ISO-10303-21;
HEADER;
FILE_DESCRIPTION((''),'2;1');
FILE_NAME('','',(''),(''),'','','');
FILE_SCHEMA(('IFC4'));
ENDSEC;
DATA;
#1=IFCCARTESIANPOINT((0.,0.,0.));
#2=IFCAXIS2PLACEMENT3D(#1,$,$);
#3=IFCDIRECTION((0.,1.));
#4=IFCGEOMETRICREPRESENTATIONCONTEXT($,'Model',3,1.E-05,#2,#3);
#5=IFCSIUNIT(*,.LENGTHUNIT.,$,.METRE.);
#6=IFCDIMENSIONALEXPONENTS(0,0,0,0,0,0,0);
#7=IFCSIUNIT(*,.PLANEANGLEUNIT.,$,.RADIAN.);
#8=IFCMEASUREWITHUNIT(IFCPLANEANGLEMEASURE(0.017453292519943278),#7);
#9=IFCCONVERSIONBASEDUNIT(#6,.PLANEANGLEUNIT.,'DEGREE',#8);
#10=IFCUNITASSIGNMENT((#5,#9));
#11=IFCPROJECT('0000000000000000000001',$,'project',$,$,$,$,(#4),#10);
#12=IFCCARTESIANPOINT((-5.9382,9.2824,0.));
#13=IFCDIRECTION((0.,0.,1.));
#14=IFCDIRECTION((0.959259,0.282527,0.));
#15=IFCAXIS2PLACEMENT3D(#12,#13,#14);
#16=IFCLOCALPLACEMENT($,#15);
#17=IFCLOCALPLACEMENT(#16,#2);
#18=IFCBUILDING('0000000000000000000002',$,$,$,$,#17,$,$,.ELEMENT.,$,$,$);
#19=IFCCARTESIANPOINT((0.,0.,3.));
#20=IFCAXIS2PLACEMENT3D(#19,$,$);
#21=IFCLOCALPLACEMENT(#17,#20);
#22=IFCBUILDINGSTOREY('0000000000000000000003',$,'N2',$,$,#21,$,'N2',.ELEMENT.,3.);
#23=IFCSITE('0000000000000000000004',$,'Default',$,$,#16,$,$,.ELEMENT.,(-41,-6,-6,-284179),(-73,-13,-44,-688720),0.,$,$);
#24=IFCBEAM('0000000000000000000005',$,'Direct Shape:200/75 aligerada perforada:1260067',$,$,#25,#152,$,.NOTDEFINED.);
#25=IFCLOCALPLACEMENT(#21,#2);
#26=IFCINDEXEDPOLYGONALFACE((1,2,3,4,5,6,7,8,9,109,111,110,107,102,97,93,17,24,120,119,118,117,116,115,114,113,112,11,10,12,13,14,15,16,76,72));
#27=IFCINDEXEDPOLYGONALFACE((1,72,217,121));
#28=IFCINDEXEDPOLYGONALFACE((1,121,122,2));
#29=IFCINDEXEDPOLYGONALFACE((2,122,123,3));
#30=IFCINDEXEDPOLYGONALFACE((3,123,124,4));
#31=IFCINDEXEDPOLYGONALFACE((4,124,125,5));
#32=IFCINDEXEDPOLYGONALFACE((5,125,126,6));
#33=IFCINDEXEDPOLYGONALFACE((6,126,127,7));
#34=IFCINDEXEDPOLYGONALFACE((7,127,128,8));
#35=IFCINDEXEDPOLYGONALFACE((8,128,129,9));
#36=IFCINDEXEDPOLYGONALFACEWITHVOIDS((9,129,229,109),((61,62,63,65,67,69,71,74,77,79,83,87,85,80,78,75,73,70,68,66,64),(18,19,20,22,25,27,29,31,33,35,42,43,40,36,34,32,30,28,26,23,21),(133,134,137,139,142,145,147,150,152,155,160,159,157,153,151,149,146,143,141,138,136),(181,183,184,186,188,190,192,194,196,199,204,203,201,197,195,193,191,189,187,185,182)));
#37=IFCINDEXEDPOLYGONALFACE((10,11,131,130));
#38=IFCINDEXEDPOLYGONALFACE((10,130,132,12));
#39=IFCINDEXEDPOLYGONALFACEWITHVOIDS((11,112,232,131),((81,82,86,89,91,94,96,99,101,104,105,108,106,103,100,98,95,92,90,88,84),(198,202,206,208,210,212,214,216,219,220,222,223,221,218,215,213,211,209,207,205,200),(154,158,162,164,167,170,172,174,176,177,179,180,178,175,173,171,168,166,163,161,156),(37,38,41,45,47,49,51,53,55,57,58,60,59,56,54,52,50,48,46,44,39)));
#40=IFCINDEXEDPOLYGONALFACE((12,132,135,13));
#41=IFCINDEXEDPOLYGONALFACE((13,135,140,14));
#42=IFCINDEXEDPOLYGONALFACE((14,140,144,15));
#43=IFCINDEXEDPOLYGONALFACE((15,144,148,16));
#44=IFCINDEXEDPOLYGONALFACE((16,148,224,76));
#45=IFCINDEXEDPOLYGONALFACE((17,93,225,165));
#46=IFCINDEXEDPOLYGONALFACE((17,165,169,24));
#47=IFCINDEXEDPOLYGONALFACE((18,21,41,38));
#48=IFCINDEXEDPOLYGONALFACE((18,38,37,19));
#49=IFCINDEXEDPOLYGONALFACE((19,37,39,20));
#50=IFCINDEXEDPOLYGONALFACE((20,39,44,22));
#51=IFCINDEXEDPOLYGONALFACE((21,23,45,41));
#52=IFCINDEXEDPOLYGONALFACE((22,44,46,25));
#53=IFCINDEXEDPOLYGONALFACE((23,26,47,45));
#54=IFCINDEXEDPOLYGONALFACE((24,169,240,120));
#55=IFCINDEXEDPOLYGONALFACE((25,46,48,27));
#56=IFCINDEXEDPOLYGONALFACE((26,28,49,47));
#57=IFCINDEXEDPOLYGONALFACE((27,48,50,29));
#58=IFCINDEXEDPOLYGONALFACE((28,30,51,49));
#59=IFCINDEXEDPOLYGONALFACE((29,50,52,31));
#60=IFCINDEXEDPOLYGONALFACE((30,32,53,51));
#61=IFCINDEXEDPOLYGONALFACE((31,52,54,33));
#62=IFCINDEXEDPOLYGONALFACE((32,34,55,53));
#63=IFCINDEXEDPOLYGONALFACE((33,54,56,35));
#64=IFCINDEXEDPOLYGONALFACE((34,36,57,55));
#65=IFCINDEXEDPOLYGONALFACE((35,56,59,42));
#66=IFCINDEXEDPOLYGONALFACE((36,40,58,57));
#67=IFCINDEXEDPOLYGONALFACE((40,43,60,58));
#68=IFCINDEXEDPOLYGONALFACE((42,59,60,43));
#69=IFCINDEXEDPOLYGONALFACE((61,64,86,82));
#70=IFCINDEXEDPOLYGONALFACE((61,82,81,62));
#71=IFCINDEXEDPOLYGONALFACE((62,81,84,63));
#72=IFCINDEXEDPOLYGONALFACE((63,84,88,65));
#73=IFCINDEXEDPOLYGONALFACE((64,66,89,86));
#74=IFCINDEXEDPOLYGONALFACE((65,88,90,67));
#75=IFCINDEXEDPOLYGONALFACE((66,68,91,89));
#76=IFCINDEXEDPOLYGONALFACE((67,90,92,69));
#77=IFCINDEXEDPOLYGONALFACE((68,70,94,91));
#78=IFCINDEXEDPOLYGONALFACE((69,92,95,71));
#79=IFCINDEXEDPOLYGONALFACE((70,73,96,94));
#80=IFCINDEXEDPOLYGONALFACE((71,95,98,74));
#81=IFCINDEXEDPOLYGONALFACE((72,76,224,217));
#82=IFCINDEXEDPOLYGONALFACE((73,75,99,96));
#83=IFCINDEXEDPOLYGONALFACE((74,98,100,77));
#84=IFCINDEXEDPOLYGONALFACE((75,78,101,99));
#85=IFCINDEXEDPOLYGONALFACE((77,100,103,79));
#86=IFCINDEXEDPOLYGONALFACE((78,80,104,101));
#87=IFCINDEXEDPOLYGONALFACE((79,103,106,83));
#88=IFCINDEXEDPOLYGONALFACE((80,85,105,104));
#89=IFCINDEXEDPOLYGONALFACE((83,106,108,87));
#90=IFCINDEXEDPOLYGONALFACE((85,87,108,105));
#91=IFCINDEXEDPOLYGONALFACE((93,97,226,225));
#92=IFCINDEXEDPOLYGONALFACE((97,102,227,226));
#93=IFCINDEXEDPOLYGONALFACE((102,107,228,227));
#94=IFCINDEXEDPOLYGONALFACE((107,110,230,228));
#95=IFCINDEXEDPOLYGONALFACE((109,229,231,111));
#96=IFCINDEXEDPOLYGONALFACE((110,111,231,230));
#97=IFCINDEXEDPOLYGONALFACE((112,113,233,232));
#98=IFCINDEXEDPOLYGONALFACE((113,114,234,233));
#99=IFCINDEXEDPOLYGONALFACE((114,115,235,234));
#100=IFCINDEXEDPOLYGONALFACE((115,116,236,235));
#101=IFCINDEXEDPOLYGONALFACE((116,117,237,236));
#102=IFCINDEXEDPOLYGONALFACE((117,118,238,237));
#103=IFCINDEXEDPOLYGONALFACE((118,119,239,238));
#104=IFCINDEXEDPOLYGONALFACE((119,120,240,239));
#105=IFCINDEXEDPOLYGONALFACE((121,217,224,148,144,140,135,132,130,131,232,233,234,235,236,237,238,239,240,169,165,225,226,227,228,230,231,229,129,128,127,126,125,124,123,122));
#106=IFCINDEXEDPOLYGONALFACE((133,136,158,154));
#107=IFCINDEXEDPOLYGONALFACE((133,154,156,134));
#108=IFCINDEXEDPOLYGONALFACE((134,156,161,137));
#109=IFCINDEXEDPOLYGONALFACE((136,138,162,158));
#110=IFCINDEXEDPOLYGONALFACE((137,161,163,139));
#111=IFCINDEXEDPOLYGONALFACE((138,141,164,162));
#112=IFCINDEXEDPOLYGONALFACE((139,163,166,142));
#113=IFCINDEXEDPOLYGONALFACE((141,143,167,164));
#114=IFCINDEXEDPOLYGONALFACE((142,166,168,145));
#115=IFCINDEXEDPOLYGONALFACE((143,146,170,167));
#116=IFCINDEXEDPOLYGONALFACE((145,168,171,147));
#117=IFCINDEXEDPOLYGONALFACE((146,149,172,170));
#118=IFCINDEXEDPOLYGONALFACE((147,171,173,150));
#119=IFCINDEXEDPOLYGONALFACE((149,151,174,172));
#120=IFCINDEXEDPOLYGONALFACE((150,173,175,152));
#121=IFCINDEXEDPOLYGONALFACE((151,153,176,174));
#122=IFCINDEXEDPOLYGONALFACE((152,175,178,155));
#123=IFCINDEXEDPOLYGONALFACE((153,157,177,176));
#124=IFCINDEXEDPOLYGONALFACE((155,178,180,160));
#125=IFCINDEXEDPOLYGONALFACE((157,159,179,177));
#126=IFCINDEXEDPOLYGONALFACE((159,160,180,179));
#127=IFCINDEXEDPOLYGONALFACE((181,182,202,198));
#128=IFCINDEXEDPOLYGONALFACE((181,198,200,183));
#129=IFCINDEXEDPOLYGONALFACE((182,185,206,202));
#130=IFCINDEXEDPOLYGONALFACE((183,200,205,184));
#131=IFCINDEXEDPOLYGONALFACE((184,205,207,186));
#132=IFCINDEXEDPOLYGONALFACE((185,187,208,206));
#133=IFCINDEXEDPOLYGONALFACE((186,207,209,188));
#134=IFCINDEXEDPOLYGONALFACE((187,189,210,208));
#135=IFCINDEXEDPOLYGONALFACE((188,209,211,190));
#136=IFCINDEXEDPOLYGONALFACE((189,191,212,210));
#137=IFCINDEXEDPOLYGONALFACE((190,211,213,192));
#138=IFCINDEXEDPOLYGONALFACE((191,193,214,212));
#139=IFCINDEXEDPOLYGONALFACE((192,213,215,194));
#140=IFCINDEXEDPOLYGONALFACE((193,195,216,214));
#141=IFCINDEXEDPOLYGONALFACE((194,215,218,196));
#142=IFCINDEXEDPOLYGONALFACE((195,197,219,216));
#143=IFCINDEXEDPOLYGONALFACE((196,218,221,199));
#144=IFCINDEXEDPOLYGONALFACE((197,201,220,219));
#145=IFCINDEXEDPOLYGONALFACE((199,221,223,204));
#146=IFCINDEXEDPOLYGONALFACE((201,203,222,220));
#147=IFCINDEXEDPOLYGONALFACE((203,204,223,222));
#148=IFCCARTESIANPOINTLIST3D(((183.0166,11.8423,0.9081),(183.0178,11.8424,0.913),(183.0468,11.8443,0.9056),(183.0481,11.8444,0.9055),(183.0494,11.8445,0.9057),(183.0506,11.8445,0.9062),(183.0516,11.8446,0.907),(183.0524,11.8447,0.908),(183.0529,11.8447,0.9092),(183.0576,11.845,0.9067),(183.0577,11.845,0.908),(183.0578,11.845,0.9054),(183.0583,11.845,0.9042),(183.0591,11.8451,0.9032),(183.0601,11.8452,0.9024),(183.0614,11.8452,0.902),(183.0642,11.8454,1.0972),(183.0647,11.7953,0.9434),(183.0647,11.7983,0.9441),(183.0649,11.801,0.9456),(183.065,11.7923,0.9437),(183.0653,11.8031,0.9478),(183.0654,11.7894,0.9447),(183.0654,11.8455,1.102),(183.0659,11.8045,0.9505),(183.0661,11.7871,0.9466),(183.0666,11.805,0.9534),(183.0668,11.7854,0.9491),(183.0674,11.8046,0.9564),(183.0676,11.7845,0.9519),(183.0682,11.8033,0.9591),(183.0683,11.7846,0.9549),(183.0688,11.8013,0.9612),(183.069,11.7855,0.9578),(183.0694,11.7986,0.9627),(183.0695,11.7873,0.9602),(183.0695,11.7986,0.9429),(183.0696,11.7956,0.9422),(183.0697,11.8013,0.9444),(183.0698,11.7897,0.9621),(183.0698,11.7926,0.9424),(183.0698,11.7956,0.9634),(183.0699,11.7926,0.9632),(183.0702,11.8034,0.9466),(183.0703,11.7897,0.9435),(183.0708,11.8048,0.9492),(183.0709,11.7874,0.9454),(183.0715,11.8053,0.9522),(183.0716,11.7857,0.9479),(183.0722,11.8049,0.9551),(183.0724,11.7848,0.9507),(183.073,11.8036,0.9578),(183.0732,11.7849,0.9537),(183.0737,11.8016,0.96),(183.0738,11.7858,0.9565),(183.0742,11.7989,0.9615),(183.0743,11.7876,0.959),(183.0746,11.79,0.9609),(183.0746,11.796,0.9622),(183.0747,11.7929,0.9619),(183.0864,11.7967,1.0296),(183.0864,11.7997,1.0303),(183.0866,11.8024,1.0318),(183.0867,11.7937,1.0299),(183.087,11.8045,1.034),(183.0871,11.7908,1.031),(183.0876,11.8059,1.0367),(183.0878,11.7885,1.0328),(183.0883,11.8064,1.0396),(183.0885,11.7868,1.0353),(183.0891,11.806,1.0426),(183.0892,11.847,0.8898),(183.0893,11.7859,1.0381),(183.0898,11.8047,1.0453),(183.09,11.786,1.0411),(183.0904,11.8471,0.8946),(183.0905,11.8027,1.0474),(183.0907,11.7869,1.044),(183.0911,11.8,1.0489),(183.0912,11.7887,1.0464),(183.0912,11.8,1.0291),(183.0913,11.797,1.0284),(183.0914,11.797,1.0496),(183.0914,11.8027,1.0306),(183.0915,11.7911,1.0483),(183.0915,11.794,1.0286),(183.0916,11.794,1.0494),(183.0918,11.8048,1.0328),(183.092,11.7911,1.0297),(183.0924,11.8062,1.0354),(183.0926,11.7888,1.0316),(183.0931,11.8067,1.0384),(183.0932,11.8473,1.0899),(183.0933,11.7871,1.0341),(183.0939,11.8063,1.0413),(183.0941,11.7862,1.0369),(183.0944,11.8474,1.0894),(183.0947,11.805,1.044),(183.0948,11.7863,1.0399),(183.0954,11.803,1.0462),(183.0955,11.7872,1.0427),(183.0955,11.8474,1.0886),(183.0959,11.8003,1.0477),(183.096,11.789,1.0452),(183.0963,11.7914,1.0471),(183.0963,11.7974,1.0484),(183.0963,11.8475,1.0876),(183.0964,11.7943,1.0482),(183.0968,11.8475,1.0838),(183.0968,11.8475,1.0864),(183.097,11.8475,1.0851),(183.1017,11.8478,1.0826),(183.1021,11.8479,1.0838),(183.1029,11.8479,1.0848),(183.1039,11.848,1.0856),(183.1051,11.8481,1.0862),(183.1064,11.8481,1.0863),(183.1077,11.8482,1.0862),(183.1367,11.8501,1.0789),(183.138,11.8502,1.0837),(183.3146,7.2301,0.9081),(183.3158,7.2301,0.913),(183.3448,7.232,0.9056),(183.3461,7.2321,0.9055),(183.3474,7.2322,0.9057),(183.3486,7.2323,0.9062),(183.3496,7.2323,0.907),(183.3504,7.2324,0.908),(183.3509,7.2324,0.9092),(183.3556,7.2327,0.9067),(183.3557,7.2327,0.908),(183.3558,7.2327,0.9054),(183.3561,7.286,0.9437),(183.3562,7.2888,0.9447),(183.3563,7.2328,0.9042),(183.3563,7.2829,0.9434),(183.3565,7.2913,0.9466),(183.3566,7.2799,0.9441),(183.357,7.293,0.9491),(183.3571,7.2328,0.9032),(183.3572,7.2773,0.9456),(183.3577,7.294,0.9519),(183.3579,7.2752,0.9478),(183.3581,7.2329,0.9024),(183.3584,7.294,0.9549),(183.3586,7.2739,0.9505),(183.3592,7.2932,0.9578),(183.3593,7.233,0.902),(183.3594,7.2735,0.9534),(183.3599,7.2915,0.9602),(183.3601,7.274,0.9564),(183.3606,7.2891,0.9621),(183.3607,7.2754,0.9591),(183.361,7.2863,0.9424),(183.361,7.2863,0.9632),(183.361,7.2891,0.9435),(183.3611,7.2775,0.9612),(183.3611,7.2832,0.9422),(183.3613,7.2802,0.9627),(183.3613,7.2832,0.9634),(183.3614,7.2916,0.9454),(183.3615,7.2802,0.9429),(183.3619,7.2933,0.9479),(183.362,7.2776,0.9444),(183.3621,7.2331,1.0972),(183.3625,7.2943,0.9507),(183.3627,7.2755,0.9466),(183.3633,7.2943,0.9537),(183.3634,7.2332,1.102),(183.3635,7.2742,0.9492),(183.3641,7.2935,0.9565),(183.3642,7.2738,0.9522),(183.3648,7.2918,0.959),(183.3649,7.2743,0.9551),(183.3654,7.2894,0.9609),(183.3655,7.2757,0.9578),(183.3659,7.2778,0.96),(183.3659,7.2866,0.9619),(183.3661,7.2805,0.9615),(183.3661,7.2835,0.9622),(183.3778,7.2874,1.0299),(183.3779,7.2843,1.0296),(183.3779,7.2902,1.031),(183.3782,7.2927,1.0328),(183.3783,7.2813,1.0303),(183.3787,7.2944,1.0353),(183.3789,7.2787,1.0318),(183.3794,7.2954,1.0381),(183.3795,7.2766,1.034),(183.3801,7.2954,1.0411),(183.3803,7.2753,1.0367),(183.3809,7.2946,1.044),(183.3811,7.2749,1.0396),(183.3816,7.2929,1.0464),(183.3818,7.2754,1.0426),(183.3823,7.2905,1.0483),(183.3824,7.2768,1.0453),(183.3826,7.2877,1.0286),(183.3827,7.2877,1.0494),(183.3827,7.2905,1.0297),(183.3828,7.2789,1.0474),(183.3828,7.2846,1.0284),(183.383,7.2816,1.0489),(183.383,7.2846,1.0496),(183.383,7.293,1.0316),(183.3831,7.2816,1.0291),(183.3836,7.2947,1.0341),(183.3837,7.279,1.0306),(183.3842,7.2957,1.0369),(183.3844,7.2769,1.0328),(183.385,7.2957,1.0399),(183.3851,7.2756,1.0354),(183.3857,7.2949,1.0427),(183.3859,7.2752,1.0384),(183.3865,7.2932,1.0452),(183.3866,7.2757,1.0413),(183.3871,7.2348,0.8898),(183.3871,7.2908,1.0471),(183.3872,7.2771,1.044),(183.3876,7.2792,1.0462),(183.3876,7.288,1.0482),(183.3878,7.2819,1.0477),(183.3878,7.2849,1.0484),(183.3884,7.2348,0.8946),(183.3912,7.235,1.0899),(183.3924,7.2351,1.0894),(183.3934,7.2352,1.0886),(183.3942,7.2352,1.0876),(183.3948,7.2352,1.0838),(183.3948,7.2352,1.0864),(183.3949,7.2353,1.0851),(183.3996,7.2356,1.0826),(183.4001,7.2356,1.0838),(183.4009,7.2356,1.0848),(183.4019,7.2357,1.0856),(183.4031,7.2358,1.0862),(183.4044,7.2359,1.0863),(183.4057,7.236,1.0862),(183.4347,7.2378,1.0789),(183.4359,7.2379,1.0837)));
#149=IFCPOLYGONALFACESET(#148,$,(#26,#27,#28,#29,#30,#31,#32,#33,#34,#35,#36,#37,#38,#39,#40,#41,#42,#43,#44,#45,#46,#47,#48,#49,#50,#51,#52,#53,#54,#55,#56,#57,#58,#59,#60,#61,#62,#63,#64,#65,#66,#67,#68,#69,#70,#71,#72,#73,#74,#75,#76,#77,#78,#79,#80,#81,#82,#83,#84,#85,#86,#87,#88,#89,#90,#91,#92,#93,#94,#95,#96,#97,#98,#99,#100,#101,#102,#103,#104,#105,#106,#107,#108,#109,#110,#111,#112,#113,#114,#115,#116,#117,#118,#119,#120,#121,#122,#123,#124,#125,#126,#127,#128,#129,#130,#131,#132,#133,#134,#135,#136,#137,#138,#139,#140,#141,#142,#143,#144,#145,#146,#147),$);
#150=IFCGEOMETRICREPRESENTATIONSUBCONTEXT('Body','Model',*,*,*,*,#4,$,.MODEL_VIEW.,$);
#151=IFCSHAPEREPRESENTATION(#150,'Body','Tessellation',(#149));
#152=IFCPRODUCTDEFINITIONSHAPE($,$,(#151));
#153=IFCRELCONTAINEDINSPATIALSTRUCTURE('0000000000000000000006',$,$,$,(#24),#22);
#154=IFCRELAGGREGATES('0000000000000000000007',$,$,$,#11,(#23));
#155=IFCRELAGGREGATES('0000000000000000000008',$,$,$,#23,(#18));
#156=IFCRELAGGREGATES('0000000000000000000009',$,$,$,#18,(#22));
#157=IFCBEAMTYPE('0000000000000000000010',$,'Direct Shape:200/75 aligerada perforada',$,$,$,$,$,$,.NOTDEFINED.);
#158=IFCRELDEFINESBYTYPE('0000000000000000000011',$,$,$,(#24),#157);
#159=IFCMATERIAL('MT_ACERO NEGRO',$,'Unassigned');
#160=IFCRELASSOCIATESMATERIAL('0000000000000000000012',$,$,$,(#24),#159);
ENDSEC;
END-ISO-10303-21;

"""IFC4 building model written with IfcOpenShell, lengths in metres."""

from ifc_helpers import new_model, entity, si_unit, converted_unit, direction, frame, frame_2d, origin, place, context, subcontext, project, spatial, circle, i_section, extrude, material, type_object, element, save


model = new_model("IFC4")

# Units and contexts
model_context = context("Model", 3, precision=1e-05, world=origin(), true_north=direction((0.0, 1.0)))
body_context = subcontext(model_context, "Body", "Model", "MODEL_VIEW")
ifc_project = project(units=[si_unit("LENGTHUNIT", "METRE"), converted_unit("PLANEANGLEUNIT", "DEGREE", entity("IfcPlaneAngleMeasure", 0.017453292519943278), si_unit("PLANEANGLEUNIT", "RADIAN"), dimensions=[0, 0, 0, 0, 0, 0, 0])], contexts=[model_context])

# Site, building, storey
site_placement = place(None, frame((-5.9382, 9.2824, 0.0), z_axis=(0.0, 0.0, 1.0), x_axis=(0.959259, 0.282527, 0.0)))
site = spatial("IfcSite", under=ifc_project, at=site_placement, Name="Default", CompositionType="ELEMENT", RefLatitude=(-41, -6, -6, -284179), RefLongitude=(-73, -13, -44, -688720), RefElevation=0.0)
building_placement = place(site_placement, origin())
building = spatial("IfcBuilding", under=site, at=building_placement, CompositionType="ELEMENT")
storey_placement = place(building_placement, frame((0.0, 0.0, 3.0)))
storey = spatial("IfcBuildingStorey", under=building, at=storey_placement, Name="N2", LongName="N2", CompositionType="ELEMENT", Elevation=3.0)

# Beam, openings
ifc_material = material(Name="MT_ACERO NEGRO", Category="Unassigned")
beam_type_1 = type_object("IfcBeamType", Name="Direct Shape:200/75 aligerada perforada", PredefinedType="NOTDEFINED")
beam_1_placement = place(storey_placement, origin())
beam_1 = element("IfcBeam", 1, at=beam_1_placement, inside=storey, type_object=beam_type_1, material=ifc_material, Name="Direct Shape:200/75 aligerada perforada:1260067", PredefinedType="NOTDEFINED", context=body_context, shape_type="SweptSolid", body=[
    extrude(i_section(OverallWidth=0.075, OverallDepth=0.2, WebThickness=0.005, FlangeThickness=0.005, FilletRadius=0.005, at=frame_2d((0.0, 0.0), x_axis=(0.0, 1.0))), frame((183.3753, 7.234, 0.9959), z_axis=(-0.064471, 0.99792, 0.0), x_axis=(0.243953, 0.015761, 0.969659)), (0.0, 0.0, 1.0), 4.6219),
])
opening_1_placement = place(storey_placement, origin())
element("IfcOpeningElement", 2, at=opening_1_placement, cuts=beam_1, PredefinedType="OPENING", context=body_context, shape_type="SweptSolid", body=[
    extrude(circle(Radius=0.0103, at=frame_2d((0.0, 0.0), x_axis=(1.0, 0.0))), frame((183.0673, 11.7947, 0.9534), z_axis=(0.967642, 0.062515, -0.244461), x_axis=(-0.064446, 0.997921, 0.0001)), (0.0, 0.0, 1.0), 0.005),
])
opening_2_placement = place(storey_placement, origin())
element("IfcOpeningElement", 3, at=opening_2_placement, cuts=beam_1, PredefinedType="OPENING", context=body_context, shape_type="SweptSolid", body=[
    extrude(circle(Radius=0.0103, at=frame_2d((0.0, 0.0), x_axis=(1.0, 0.0))), frame((183.089, 11.7961, 1.0396), z_axis=(0.967642, 0.062515, -0.244461), x_axis=(-0.064446, 0.997921, 0.0001)), (0.0, 0.0, 1.0), 0.005),
])
opening_3_placement = place(storey_placement, origin())
element("IfcOpeningElement", 4, at=opening_3_placement, cuts=beam_1, PredefinedType="OPENING", context=body_context, shape_type="SweptSolid", body=[
    extrude(circle(Radius=0.0103, at=frame_2d((0.0, 0.0), x_axis=(1.0, 0.0))), frame((183.3804, 7.2852, 1.0396), z_axis=(0.967642, 0.062515, -0.244461), x_axis=(0.064497, -0.997918, 0.0001)), (0.0, 0.0, 1.0), 0.005),
])
opening_4_placement = place(storey_placement, origin())
element("IfcOpeningElement", 5, at=opening_4_placement, cuts=beam_1, PredefinedType="OPENING", context=body_context, shape_type="SweptSolid", body=[
    extrude(circle(Radius=0.0103, at=frame_2d((0.0, 0.0), x_axis=(1.0, 0.0))), frame((183.3587, 7.2838, 0.9534), z_axis=(0.967642, 0.062515, -0.244461), x_axis=(0.064496, -0.997918, 0.0001)), (0.0, 0.0, 1.0), 0.005),
])

save(model, "model.ifc")
